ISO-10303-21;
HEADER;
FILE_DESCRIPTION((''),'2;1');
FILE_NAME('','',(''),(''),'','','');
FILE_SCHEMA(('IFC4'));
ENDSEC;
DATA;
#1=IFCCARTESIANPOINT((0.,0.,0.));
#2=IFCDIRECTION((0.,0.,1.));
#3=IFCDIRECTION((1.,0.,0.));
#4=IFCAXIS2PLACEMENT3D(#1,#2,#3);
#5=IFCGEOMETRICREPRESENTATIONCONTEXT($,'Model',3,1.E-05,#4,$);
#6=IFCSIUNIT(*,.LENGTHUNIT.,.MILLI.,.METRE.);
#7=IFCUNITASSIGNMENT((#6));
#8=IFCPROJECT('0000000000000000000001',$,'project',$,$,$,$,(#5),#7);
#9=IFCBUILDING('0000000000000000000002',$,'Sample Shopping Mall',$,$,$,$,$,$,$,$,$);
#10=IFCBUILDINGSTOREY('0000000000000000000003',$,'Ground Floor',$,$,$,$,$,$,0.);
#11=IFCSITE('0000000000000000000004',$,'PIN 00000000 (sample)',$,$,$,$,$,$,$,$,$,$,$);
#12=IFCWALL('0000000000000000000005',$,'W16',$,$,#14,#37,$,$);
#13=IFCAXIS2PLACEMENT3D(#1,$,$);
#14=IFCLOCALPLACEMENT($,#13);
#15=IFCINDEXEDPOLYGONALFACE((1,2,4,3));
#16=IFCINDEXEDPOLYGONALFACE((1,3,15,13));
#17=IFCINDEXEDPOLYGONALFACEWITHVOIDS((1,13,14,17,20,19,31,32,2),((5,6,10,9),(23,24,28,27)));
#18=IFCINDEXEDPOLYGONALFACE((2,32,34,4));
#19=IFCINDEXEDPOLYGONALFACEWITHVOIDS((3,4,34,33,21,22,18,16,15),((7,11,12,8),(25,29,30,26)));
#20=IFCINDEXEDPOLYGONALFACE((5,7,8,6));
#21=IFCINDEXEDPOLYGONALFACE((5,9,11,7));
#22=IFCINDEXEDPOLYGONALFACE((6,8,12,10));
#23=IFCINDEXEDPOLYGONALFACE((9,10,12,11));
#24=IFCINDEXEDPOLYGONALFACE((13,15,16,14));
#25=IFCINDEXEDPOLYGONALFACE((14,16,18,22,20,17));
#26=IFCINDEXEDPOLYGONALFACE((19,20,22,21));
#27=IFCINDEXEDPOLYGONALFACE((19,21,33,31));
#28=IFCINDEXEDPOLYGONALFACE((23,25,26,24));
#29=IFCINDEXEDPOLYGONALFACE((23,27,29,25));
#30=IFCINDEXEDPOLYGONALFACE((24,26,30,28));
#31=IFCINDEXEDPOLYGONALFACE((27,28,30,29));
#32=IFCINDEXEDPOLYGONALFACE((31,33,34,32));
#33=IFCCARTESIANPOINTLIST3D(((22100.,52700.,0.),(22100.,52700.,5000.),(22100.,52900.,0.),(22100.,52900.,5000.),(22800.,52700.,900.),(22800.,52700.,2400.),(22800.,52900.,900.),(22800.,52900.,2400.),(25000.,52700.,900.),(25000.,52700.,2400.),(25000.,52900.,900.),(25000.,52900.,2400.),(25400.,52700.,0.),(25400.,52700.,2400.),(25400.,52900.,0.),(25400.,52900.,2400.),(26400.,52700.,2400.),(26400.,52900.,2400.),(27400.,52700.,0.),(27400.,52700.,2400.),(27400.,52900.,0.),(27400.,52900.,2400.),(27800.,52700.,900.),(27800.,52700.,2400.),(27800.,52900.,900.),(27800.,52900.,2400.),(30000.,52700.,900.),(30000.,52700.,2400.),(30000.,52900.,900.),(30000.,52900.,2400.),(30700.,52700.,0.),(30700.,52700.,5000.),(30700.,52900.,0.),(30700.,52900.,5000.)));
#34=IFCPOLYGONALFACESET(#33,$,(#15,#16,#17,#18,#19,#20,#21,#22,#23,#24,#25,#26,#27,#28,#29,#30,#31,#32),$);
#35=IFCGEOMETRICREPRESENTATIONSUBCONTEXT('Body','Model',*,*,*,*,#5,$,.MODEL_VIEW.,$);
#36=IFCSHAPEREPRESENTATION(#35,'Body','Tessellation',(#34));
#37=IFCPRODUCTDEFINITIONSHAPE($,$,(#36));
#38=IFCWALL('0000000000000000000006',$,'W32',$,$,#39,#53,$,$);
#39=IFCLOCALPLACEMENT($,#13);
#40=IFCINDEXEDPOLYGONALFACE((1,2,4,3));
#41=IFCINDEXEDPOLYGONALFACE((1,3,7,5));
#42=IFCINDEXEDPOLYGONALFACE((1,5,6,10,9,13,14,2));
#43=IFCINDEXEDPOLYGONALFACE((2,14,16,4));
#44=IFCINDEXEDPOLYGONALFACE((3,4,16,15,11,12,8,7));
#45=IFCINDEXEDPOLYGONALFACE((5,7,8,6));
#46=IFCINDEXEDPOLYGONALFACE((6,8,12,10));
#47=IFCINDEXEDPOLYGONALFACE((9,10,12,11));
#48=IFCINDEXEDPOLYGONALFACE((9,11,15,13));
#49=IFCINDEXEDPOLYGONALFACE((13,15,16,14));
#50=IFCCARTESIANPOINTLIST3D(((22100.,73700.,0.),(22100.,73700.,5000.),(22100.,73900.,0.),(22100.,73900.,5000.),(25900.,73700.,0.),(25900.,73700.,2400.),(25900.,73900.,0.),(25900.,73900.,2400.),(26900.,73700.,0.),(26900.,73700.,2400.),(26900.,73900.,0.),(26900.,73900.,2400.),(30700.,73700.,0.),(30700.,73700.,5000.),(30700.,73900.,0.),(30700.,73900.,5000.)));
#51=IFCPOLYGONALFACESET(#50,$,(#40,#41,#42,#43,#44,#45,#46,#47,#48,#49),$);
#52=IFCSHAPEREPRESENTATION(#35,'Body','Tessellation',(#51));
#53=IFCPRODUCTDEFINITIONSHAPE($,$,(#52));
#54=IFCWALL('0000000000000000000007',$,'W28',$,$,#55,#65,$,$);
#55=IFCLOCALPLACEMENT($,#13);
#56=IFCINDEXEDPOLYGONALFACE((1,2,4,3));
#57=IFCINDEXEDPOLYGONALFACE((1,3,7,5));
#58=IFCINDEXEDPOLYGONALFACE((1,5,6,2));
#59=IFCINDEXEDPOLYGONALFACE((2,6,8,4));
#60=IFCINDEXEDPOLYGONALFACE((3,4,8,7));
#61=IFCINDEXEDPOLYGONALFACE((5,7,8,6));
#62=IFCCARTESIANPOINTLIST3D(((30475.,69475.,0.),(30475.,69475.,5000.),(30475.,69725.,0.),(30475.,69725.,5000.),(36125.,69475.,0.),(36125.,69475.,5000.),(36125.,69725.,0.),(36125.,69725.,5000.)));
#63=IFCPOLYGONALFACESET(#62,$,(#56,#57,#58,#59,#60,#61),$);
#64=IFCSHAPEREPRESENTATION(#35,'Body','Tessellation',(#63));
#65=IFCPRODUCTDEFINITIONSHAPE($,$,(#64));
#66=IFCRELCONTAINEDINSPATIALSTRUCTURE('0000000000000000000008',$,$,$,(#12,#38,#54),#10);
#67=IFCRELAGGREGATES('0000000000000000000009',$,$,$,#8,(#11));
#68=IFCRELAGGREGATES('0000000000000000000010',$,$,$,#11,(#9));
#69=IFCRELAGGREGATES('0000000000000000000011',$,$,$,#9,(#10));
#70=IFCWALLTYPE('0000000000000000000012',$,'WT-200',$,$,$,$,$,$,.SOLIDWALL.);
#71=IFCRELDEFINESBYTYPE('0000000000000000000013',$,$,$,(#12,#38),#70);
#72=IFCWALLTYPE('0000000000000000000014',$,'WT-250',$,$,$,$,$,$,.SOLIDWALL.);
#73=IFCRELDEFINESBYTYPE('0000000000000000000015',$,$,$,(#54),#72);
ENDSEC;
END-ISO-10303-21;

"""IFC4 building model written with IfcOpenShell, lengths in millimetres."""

from ifc_helpers import new_model, si_unit, frame, origin_with_axes, place, context, subcontext, project, spatial, indexed_curve, outline, extrude, type_object, element, save


model = new_model("IFC4")

# Units and contexts
model_context = context("Model", 3, precision=1e-05, world=origin_with_axes())
body_context = subcontext(model_context, "Body", "Model", "MODEL_VIEW")
ifc_project = project(units=[si_unit("LENGTHUNIT", "METRE", prefix="MILLI")], contexts=[model_context])

# Site, building, storey
site = spatial("IfcSite", under=ifc_project, Name="PIN 00000000 (sample)")
building = spatial("IfcBuilding", under=site, Name="Sample Shopping Mall")
storey = spatial("IfcBuildingStorey", under=building, Name="Ground Floor", Elevation=0.0)

# Wall, openings
wall_type_1 = type_object("IfcWallType", Name="WT-200", PredefinedType="SOLIDWALL")
wall_1_placement = place(None, frame((22100.0, 52700.0, 0.0), z_axis=(0.0, 0.0, 1.0), x_axis=(1.0, 0.0, 0.0)))
wall_1 = element("IfcWall", 1, at=wall_1_placement, inside=storey, type_object=wall_type_1, Name="W16", context=body_context, shape_type="SweptSolid", body=[
    extrude(outline(indexed_curve([(0.0, 0.0), (0.0, 200.0), (8600.0, 200.0), (8600.0, 0.0), (0.0, 0.0)], self_intersect=False)), origin_with_axes(), (0.0, 0.0, 1.0), 5000.0),
])
opening_1_placement = place(wall_1_placement, frame((3300.0, -100.0, 0.0), z_axis=(0.0, 0.0, 1.0), x_axis=(1.0, 0.0, 0.0)))
element("IfcOpeningElement", 2, at=opening_1_placement, cuts=wall_1, context=body_context, shape_type="SweptSolid", body=[
    extrude(outline(indexed_curve([(0.0, 0.0), (0.0, 400.0), (1000.0, 400.0), (1000.0, 0.0), (0.0, 0.0)], self_intersect=False)), origin_with_axes(), (0.0, 0.0, 1.0), 2400.0),
])
opening_2_placement = place(wall_1_placement, frame((4300.0, -100.0, 0.0), z_axis=(0.0, 0.0, 1.0), x_axis=(1.0, 0.0, 0.0)))
element("IfcOpeningElement", 3, at=opening_2_placement, cuts=wall_1, context=body_context, shape_type="SweptSolid", body=[
    extrude(outline(indexed_curve([(0.0, 0.0), (0.0, 400.0), (1000.0, 400.0), (1000.0, 0.0), (0.0, 0.0)], self_intersect=False)), origin_with_axes(), (0.0, 0.0, 1.0), 2400.0),
])
opening_3_placement = place(wall_1_placement, frame((700.0, -100.0, 900.0), z_axis=(0.0, 0.0, 1.0), x_axis=(1.0, 0.0, 0.0)))
element("IfcOpeningElement", 4, at=opening_3_placement, cuts=wall_1, context=body_context, shape_type="SweptSolid", body=[
    extrude(outline(indexed_curve([(0.0, 0.0), (0.0, 400.0), (2200.0, 400.0), (2200.0, 0.0), (0.0, 0.0)], self_intersect=False)), origin_with_axes(), (0.0, 0.0, 1.0), 1500.0),
])
opening_4_placement = place(wall_1_placement, frame((5700.0, -100.0, 900.0), z_axis=(0.0, 0.0, 1.0), x_axis=(1.0, 0.0, 0.0)))
element("IfcOpeningElement", 5, at=opening_4_placement, cuts=wall_1, context=body_context, shape_type="SweptSolid", body=[
    extrude(outline(indexed_curve([(0.0, 0.0), (0.0, 400.0), (2200.0, 400.0), (2200.0, 0.0), (0.0, 0.0)], self_intersect=False)), origin_with_axes(), (0.0, 0.0, 1.0), 1500.0),
])

# Wall, opening
wall_2_placement = place(None, frame((22100.0, 73700.0, 0.0), z_axis=(0.0, 0.0, 1.0), x_axis=(1.0, 0.0, 0.0)))
wall_2 = element("IfcWall", 6, at=wall_2_placement, inside=storey, type_object=wall_type_1, Name="W32", context=body_context, shape_type="SweptSolid", body=[
    extrude(outline(indexed_curve([(0.0, 0.0), (0.0, 200.0), (8600.0, 200.0), (8600.0, 0.0), (0.0, 0.0)], self_intersect=False)), origin_with_axes(), (0.0, 0.0, 1.0), 5000.0),
])
opening_5_placement = place(wall_2_placement, frame((3800.0, -100.0, 0.0), z_axis=(0.0, 0.0, 1.0), x_axis=(1.0, 0.0, 0.0)))
element("IfcOpeningElement", 7, at=opening_5_placement, cuts=wall_2, context=body_context, shape_type="SweptSolid", body=[
    extrude(outline(indexed_curve([(0.0, 0.0), (0.0, 400.0), (1000.0, 400.0), (1000.0, 0.0), (0.0, 0.0)], self_intersect=False)), origin_with_axes(), (0.0, 0.0, 1.0), 2400.0),
])

# Shared definitions
wall_type_2 = type_object("IfcWallType", Name="WT-250", PredefinedType="SOLIDWALL")

# Wall
wall_3_placement = place(None, frame((30475.0, 69475.0, 0.0), z_axis=(0.0, 0.0, 1.0), x_axis=(1.0, 0.0, 0.0)))
element("IfcWall", 8, at=wall_3_placement, inside=storey, type_object=wall_type_2, Name="W28", context=body_context, shape_type="SweptSolid", body=[
    extrude(outline(indexed_curve([(0.0, 0.0), (0.0, 250.0), (5650.0, 250.0), (5650.0, 0.0), (0.0, 0.0)], self_intersect=False)), origin_with_axes(), (0.0, 0.0, 1.0), 5000.0),
])

save(model, "model.ifc")
